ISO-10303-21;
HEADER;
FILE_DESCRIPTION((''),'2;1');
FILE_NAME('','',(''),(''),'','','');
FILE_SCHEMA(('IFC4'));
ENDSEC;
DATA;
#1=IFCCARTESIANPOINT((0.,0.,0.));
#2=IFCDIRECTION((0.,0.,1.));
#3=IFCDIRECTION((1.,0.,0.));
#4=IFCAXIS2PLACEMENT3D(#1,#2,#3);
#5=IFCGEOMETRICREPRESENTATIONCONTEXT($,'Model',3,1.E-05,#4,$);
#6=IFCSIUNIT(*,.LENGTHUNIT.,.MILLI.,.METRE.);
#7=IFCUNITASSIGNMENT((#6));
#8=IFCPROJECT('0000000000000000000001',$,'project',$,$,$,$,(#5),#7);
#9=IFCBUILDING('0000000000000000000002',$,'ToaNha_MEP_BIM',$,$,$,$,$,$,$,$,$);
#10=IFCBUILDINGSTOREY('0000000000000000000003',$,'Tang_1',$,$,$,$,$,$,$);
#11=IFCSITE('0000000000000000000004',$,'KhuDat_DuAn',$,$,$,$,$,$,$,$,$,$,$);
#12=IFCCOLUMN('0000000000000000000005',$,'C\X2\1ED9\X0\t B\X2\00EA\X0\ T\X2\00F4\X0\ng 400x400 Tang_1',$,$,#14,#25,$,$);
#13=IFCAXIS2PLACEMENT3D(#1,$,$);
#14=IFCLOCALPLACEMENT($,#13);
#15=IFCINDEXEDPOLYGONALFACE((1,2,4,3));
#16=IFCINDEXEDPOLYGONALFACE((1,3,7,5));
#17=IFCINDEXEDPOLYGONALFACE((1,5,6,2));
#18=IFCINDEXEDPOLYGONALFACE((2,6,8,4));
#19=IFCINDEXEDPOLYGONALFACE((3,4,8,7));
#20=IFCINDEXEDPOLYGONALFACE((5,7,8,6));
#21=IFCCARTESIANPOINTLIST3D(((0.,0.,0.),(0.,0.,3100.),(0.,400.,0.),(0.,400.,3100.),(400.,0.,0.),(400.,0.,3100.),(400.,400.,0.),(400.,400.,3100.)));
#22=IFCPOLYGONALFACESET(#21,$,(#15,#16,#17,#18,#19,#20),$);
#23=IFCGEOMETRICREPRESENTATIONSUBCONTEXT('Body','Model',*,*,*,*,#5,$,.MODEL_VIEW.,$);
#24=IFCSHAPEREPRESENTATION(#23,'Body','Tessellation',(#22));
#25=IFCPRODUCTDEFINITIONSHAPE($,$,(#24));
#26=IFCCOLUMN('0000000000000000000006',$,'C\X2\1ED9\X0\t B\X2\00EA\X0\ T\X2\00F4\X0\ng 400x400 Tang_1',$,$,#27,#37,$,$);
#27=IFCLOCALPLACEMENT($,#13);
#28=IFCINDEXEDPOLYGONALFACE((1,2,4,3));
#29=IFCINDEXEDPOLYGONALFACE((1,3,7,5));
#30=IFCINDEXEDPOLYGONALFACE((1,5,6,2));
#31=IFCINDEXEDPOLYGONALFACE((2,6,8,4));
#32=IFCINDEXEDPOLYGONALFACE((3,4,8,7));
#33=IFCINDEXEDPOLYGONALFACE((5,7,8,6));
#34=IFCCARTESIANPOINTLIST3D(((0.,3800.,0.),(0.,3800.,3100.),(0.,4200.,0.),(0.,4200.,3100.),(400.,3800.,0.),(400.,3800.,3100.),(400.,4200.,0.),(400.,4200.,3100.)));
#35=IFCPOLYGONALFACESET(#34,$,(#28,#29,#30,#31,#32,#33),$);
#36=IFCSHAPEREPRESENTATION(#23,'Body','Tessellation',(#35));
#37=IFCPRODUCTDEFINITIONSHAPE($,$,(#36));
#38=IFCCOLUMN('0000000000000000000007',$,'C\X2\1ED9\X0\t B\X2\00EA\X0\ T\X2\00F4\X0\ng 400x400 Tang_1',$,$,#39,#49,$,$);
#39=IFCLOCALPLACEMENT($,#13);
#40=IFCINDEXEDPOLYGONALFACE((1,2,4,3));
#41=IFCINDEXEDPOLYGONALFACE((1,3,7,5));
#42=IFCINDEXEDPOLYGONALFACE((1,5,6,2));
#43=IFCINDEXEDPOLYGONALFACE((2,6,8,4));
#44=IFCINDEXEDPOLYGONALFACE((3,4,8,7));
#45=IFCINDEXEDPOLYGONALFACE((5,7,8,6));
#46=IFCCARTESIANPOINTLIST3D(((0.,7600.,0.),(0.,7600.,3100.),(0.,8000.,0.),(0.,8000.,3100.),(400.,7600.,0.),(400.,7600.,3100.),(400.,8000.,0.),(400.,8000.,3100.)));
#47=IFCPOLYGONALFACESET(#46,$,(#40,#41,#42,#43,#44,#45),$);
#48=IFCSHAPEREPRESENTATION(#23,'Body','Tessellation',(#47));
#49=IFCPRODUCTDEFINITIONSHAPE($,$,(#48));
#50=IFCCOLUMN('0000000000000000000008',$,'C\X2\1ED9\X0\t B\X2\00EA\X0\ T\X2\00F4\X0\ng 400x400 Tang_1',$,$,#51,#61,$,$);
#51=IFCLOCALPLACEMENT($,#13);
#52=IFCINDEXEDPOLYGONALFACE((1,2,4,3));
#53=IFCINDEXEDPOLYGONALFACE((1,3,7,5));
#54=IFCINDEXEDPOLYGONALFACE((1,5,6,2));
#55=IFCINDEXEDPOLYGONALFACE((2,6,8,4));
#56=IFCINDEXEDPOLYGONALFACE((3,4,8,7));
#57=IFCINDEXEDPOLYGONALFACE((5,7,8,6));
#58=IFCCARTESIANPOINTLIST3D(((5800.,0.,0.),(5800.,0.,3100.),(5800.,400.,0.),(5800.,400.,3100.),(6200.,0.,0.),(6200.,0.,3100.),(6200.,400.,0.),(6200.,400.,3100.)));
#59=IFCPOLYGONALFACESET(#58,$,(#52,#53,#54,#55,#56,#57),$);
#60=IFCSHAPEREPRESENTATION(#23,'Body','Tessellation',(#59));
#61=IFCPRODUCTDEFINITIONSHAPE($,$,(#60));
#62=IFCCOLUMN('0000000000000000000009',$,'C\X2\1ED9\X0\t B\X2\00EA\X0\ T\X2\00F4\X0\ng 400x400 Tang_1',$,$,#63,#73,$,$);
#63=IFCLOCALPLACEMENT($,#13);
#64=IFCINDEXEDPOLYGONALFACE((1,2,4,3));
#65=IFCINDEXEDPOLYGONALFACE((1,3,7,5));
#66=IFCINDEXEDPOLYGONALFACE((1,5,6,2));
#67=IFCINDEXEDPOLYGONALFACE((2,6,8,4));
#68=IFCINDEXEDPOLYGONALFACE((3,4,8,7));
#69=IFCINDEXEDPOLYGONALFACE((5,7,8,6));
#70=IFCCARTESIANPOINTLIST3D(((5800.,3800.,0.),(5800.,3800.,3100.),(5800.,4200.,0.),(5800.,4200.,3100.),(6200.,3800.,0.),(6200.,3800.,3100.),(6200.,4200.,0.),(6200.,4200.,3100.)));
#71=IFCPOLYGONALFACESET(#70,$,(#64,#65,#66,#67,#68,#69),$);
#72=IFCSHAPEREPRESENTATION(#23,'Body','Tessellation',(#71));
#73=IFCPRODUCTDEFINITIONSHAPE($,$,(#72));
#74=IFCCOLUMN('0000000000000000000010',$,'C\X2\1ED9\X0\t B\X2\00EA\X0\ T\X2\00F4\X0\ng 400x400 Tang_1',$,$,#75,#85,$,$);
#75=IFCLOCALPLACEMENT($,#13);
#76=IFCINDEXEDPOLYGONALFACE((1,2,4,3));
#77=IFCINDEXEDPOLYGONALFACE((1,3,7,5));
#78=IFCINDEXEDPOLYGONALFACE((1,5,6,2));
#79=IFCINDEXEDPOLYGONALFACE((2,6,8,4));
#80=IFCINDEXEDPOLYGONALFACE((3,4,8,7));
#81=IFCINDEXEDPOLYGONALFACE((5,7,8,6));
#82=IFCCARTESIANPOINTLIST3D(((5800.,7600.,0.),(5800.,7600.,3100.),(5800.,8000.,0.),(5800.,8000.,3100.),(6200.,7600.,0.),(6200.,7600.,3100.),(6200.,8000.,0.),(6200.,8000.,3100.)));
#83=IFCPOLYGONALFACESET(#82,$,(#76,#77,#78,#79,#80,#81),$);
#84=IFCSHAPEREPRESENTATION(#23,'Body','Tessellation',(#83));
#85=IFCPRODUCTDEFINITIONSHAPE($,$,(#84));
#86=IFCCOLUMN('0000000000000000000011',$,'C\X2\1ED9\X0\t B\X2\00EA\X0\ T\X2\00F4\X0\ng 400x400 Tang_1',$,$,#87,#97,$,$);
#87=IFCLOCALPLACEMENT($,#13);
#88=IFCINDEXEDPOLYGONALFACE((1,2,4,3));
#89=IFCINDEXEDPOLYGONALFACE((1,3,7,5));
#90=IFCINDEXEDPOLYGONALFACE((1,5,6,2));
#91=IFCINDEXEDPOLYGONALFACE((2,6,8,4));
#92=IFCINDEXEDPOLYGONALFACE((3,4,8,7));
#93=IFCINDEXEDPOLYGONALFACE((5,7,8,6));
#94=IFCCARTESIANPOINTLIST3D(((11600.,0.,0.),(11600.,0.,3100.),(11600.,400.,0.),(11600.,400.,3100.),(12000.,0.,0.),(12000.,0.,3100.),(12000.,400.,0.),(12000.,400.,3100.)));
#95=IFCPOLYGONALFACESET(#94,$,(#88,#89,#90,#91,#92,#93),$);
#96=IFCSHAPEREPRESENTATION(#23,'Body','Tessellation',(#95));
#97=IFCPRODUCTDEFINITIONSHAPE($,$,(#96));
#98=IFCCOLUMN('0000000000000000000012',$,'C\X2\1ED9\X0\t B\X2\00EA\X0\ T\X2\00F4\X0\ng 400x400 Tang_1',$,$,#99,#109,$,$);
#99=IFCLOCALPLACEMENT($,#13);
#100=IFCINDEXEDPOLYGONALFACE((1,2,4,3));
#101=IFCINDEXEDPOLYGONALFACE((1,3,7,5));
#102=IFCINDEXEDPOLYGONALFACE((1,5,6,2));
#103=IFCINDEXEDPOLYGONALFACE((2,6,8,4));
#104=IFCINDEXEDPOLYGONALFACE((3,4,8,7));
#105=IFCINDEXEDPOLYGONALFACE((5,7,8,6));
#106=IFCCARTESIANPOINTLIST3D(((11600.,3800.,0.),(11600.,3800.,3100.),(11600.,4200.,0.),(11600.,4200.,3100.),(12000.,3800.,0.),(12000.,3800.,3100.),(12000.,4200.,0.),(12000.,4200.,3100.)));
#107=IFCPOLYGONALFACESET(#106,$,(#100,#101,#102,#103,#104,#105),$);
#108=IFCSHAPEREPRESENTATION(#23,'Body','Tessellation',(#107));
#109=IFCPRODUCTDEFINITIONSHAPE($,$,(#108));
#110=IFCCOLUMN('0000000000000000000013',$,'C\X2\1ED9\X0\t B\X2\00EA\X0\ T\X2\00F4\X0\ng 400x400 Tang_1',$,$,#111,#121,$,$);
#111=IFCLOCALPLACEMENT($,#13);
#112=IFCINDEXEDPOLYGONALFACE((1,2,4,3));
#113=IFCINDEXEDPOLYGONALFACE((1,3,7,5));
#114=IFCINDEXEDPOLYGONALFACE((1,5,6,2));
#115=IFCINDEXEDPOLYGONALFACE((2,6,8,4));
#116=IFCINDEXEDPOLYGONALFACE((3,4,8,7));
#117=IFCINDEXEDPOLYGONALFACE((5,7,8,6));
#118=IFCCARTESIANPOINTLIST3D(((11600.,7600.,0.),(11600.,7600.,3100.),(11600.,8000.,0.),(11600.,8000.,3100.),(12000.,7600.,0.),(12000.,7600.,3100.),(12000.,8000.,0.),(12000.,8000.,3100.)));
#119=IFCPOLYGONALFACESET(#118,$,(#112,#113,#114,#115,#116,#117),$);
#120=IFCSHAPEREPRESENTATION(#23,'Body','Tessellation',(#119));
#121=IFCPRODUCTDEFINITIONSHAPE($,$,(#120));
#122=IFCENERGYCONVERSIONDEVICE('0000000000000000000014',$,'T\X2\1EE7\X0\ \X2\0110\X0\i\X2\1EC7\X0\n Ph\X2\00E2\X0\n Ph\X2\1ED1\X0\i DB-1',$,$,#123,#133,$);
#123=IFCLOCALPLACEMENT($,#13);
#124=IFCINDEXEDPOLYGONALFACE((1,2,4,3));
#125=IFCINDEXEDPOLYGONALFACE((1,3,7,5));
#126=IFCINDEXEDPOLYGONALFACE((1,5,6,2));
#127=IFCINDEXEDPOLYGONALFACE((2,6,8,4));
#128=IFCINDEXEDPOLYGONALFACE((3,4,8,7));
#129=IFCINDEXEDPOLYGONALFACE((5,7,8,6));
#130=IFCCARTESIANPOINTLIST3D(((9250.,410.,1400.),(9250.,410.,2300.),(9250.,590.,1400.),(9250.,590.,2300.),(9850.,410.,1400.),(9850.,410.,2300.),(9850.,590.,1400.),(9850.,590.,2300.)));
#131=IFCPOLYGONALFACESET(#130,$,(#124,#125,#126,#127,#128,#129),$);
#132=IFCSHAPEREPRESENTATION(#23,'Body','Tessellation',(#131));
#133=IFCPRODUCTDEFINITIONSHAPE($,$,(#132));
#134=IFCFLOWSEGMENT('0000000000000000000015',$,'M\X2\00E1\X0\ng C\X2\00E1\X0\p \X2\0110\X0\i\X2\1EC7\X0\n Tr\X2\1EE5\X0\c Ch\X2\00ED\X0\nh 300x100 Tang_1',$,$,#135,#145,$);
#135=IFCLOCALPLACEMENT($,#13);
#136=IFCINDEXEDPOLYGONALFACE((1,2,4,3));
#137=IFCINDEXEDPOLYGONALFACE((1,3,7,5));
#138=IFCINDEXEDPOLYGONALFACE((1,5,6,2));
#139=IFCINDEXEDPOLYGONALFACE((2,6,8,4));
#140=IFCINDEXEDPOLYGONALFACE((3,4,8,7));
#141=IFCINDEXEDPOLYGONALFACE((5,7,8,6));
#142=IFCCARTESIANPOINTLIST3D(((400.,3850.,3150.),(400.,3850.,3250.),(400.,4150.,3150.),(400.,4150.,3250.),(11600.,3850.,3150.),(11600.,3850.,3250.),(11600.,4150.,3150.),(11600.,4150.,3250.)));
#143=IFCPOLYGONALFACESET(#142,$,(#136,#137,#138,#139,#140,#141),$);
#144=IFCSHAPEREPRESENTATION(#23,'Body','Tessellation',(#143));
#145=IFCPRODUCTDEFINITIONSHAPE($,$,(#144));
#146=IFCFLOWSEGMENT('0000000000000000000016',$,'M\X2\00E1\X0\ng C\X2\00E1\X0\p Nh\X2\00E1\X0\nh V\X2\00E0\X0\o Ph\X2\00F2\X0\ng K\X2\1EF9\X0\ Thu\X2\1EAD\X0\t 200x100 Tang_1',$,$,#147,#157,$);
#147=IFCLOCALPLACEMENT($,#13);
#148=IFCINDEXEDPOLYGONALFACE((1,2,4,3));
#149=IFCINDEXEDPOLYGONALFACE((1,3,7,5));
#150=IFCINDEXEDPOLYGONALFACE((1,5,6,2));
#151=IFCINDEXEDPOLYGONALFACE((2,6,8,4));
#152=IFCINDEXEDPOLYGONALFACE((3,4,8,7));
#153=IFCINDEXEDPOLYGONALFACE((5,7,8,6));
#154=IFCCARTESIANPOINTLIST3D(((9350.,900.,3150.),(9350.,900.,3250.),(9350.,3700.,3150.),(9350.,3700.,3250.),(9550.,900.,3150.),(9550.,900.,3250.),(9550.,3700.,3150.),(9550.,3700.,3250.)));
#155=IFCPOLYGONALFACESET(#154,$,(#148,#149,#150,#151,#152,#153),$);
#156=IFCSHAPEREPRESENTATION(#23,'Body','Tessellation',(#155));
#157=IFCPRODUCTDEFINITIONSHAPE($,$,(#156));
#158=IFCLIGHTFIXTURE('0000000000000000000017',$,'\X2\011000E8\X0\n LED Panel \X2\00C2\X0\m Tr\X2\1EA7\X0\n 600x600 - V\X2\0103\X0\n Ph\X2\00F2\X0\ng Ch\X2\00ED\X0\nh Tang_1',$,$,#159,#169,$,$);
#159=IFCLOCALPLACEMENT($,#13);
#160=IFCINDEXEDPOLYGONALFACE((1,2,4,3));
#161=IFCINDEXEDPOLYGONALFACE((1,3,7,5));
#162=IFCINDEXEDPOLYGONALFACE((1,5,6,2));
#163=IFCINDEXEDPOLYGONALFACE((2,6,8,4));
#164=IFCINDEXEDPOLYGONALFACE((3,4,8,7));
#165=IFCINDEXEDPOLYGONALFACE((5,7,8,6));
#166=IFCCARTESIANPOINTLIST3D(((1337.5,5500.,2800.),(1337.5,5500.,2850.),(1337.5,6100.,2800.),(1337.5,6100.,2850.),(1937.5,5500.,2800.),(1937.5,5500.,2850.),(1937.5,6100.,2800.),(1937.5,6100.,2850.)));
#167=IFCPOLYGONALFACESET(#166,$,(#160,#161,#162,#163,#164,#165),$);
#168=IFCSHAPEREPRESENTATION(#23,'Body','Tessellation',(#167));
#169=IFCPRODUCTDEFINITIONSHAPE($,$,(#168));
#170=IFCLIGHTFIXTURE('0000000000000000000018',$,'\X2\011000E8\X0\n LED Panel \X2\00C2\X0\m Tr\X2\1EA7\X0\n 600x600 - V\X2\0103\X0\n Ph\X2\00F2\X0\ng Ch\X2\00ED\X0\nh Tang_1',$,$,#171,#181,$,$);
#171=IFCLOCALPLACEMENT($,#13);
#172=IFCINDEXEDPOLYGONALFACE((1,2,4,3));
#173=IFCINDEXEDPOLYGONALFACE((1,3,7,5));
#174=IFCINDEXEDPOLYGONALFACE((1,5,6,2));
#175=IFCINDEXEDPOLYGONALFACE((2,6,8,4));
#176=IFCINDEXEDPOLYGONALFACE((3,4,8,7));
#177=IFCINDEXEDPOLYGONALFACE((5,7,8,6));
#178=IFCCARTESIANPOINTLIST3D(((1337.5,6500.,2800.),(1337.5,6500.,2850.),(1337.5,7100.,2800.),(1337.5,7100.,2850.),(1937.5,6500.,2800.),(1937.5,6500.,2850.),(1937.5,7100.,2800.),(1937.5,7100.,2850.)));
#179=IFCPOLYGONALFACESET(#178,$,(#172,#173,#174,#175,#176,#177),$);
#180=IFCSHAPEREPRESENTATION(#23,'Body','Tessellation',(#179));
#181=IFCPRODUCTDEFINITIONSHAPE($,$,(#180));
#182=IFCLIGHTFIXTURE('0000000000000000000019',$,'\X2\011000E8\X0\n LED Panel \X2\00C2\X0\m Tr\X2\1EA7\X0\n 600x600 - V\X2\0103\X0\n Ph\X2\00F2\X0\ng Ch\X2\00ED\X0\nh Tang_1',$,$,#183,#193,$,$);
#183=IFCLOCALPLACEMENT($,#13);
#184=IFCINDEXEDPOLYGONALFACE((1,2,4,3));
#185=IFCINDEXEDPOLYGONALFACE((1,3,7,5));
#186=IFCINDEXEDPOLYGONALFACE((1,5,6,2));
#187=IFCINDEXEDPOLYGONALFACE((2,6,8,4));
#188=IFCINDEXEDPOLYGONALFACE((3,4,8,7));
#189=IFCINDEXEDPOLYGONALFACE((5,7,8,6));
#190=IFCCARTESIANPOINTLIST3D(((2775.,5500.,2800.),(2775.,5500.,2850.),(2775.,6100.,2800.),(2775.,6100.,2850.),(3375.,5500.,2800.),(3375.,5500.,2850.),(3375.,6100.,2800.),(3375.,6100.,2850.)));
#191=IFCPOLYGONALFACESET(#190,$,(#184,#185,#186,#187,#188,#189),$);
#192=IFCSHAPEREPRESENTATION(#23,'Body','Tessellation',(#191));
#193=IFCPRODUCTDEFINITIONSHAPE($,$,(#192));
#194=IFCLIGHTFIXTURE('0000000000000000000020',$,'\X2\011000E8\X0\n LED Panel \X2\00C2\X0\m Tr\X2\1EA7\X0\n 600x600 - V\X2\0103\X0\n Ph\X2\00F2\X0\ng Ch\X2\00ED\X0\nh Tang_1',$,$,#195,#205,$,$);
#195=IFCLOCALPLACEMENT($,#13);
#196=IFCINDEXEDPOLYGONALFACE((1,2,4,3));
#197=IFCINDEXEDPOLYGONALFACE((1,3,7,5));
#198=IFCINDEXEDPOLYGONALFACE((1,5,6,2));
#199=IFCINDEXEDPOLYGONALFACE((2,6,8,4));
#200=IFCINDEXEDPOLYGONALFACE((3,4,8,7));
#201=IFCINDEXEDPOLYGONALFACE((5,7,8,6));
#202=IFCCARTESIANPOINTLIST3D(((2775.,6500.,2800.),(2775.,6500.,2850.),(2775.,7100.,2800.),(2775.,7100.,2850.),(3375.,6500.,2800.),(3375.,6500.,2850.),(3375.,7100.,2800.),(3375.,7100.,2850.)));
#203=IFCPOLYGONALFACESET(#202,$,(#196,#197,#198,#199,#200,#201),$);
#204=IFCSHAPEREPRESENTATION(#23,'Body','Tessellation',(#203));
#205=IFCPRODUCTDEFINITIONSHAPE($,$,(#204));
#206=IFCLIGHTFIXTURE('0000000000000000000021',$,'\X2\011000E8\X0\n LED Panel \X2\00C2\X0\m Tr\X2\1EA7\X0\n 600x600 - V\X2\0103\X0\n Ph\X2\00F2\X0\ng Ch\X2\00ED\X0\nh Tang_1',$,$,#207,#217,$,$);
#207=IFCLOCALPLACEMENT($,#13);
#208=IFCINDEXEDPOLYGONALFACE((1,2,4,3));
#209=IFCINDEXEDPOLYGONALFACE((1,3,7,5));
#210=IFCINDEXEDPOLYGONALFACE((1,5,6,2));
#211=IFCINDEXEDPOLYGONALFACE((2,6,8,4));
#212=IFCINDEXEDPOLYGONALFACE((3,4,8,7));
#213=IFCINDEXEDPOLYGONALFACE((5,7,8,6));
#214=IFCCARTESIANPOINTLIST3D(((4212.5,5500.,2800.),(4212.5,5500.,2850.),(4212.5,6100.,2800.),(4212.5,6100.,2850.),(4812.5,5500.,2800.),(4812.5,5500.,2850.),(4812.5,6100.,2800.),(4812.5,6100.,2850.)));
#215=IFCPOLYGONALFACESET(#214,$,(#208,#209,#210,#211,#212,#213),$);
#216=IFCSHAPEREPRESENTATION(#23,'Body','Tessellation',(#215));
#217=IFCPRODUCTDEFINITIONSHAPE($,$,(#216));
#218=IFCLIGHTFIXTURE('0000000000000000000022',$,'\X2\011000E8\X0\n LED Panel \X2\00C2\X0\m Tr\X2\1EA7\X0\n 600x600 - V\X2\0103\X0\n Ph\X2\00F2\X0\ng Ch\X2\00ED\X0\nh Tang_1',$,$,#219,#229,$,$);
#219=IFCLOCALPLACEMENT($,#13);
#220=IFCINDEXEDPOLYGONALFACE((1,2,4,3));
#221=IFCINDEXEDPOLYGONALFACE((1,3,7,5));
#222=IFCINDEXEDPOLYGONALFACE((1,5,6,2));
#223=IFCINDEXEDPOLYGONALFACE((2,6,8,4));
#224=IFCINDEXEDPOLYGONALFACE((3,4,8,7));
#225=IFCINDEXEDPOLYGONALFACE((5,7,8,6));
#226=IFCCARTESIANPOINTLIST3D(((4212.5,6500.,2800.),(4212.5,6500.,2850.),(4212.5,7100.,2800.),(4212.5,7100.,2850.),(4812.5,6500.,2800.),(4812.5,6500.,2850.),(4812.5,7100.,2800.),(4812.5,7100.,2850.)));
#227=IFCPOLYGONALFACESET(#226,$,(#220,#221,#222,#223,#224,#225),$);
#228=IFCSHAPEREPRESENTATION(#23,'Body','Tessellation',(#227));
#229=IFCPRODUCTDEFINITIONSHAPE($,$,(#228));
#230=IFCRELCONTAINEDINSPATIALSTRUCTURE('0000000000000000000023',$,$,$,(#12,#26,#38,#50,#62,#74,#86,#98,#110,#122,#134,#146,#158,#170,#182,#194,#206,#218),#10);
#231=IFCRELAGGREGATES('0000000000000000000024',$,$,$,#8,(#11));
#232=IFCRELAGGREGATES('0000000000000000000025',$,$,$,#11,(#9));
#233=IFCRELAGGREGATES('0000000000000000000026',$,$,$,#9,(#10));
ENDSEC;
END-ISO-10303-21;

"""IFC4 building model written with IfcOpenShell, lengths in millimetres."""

from ifc_helpers import new_model, si_unit, frame, origin_with_axes, context, subcontext, project, spatial, polyline, outline, extrude, element, save


model = new_model("IFC4")

# Units and contexts
model_context = context("Model", 3, precision=1e-05, world=origin_with_axes())
body_context = subcontext(model_context, "Body", "Model", "MODEL_VIEW")
ifc_project = project(units=[si_unit("LENGTHUNIT", "METRE", prefix="MILLI")], contexts=[model_context])

# Site, building, storey
site = spatial("IfcSite", under=ifc_project, Name="KhuDat_DuAn")
building = spatial("IfcBuilding", under=site, Name="ToaNha_MEP_BIM")
storey = spatial("IfcBuildingStorey", under=building, Name="Tang_1")

# Columns
element("IfcColumn", 1, inside=storey, Name="Cột Bê Tông 400x400 Tang_1", context=body_context, shape_type="SweptSolid", body=[
    extrude(outline(polyline([(0.0, 0.0), (400.0, 0.0), (400.0, 400.0), (0.0, 400.0), (0.0, 0.0)])), origin_with_axes(), (0.0, 0.0, 1.0), 3100.0),
])
element("IfcColumn", 2, inside=storey, Name="Cột Bê Tông 400x400 Tang_1", context=body_context, shape_type="SweptSolid", body=[
    extrude(outline(polyline([(0.0, 3800.0), (400.0, 3800.0), (400.0, 4200.0), (0.0, 4200.0), (0.0, 3800.0)])), origin_with_axes(), (0.0, 0.0, 1.0), 3100.0),
])
element("IfcColumn", 3, inside=storey, Name="Cột Bê Tông 400x400 Tang_1", context=body_context, shape_type="SweptSolid", body=[
    extrude(outline(polyline([(0.0, 7600.0), (400.0, 7600.0), (400.0, 8000.0), (0.0, 8000.0), (0.0, 7600.0)])), origin_with_axes(), (0.0, 0.0, 1.0), 3100.0),
])
element("IfcColumn", 4, inside=storey, Name="Cột Bê Tông 400x400 Tang_1", context=body_context, shape_type="SweptSolid", body=[
    extrude(outline(polyline([(5800.0, 0.0), (6200.0, 0.0), (6200.0, 400.0), (5800.0, 400.0), (5800.0, 0.0)])), origin_with_axes(), (0.0, 0.0, 1.0), 3100.0),
])
element("IfcColumn", 5, inside=storey, Name="Cột Bê Tông 400x400 Tang_1", context=body_context, shape_type="SweptSolid", body=[
    extrude(outline(polyline([(5800.0, 3800.0), (6200.0, 3800.0), (6200.0, 4200.0), (5800.0, 4200.0), (5800.0, 3800.0)])), origin_with_axes(), (0.0, 0.0, 1.0), 3100.0),
])
element("IfcColumn", 6, inside=storey, Name="Cột Bê Tông 400x400 Tang_1", context=body_context, shape_type="SweptSolid", body=[
    extrude(outline(polyline([(5800.0, 7600.0), (6200.0, 7600.0), (6200.0, 8000.0), (5800.0, 8000.0), (5800.0, 7600.0)])), origin_with_axes(), (0.0, 0.0, 1.0), 3100.0),
])
element("IfcColumn", 7, inside=storey, Name="Cột Bê Tông 400x400 Tang_1", context=body_context, shape_type="SweptSolid", body=[
    extrude(outline(polyline([(11600.0, 0.0), (12000.0, 0.0), (12000.0, 400.0), (11600.0, 400.0), (11600.0, 0.0)])), origin_with_axes(), (0.0, 0.0, 1.0), 3100.0),
])
element("IfcColumn", 8, inside=storey, Name="Cột Bê Tông 400x400 Tang_1", context=body_context, shape_type="SweptSolid", body=[
    extrude(outline(polyline([(11600.0, 3800.0), (12000.0, 3800.0), (12000.0, 4200.0), (11600.0, 4200.0), (11600.0, 3800.0)])), origin_with_axes(), (0.0, 0.0, 1.0), 3100.0),
])
element("IfcColumn", 9, inside=storey, Name="Cột Bê Tông 400x400 Tang_1", context=body_context, shape_type="SweptSolid", body=[
    extrude(outline(polyline([(11600.0, 7600.0), (12000.0, 7600.0), (12000.0, 8000.0), (11600.0, 8000.0), (11600.0, 7600.0)])), origin_with_axes(), (0.0, 0.0, 1.0), 3100.0),
])

# Energy conversion device
element("IfcEnergyConversionDevice", 10, inside=storey, Name="Tủ Điện Phân Phối DB-1", context=body_context, shape_type="SweptSolid", body=[
    extrude(outline(polyline([(9250.0, 410.0), (9850.0, 410.0), (9850.0, 590.0), (9250.0, 590.0), (9250.0, 410.0)])), frame((0.0, 0.0, 1400.0), z_axis=(0.0, 0.0, 1.0), x_axis=(1.0, 0.0, 0.0)), (0.0, 0.0, 1.0), 900.0),
])

# Flow segments
element("IfcFlowSegment", 11, inside=storey, Name="Máng Cáp Điện Trục Chính 300x100 Tang_1", context=body_context, shape_type="SweptSolid", body=[
    extrude(outline(polyline([(400.0, 3850.0), (11600.0, 3850.0), (11600.0, 4150.0), (400.0, 4150.0), (400.0, 3850.0)])), frame((0.0, 0.0, 3150.0), z_axis=(0.0, 0.0, 1.0), x_axis=(1.0, 0.0, 0.0)), (0.0, 0.0, 1.0), 100.0),
])
element("IfcFlowSegment", 12, inside=storey, Name="Máng Cáp Nhánh Vào Phòng Kỹ Thuật 200x100 Tang_1", context=body_context, shape_type="SweptSolid", body=[
    extrude(outline(polyline([(9350.0, 900.0), (9550.0, 900.0), (9550.0, 3700.0), (9350.0, 3700.0), (9350.0, 900.0)])), frame((0.0, 0.0, 3150.0), z_axis=(0.0, 0.0, 1.0), x_axis=(1.0, 0.0, 0.0)), (0.0, 0.0, 1.0), 100.0),
])

# Light fixtures
element("IfcLightFixture", 13, inside=storey, Name="Đèn LED Panel Âm Trần 600x600 - Văn Phòng Chính Tang_1", context=body_context, shape_type="SweptSolid", body=[
    extrude(outline(polyline([(1337.5, 5500.0), (1937.5, 5500.0), (1937.5, 6100.0), (1337.5, 6100.0), (1337.5, 5500.0)])), frame((0.0, 0.0, 2800.0), z_axis=(0.0, 0.0, 1.0), x_axis=(1.0, 0.0, 0.0)), (0.0, 0.0, 1.0), 50.0),
])
element("IfcLightFixture", 14, inside=storey, Name="Đèn LED Panel Âm Trần 600x600 - Văn Phòng Chính Tang_1", context=body_context, shape_type="SweptSolid", body=[
    extrude(outline(polyline([(1337.5, 6500.0), (1937.5, 6500.0), (1937.5, 7100.0), (1337.5, 7100.0), (1337.5, 6500.0)])), frame((0.0, 0.0, 2800.0), z_axis=(0.0, 0.0, 1.0), x_axis=(1.0, 0.0, 0.0)), (0.0, 0.0, 1.0), 50.0),
])
element("IfcLightFixture", 15, inside=storey, Name="Đèn LED Panel Âm Trần 600x600 - Văn Phòng Chính Tang_1", context=body_context, shape_type="SweptSolid", body=[
    extrude(outline(polyline([(2775.0, 5500.0), (3375.0, 5500.0), (3375.0, 6100.0), (2775.0, 6100.0), (2775.0, 5500.0)])), frame((0.0, 0.0, 2800.0), z_axis=(0.0, 0.0, 1.0), x_axis=(1.0, 0.0, 0.0)), (0.0, 0.0, 1.0), 50.0),
])
element("IfcLightFixture", 16, inside=storey, Name="Đèn LED Panel Âm Trần 600x600 - Văn Phòng Chính Tang_1", context=body_context, shape_type="SweptSolid", body=[
    extrude(outline(polyline([(2775.0, 6500.0), (3375.0, 6500.0), (3375.0, 7100.0), (2775.0, 7100.0), (2775.0, 6500.0)])), frame((0.0, 0.0, 2800.0), z_axis=(0.0, 0.0, 1.0), x_axis=(1.0, 0.0, 0.0)), (0.0, 0.0, 1.0), 50.0),
])
element("IfcLightFixture", 17, inside=storey, Name="Đèn LED Panel Âm Trần 600x600 - Văn Phòng Chính Tang_1", context=body_context, shape_type="SweptSolid", body=[
    extrude(outline(polyline([(4212.5, 5500.0), (4812.5, 5500.0), (4812.5, 6100.0), (4212.5, 6100.0), (4212.5, 5500.0)])), frame((0.0, 0.0, 2800.0), z_axis=(0.0, 0.0, 1.0), x_axis=(1.0, 0.0, 0.0)), (0.0, 0.0, 1.0), 50.0),
])
element("IfcLightFixture", 18, inside=storey, Name="Đèn LED Panel Âm Trần 600x600 - Văn Phòng Chính Tang_1", context=body_context, shape_type="SweptSolid", body=[
    extrude(outline(polyline([(4212.5, 6500.0), (4812.5, 6500.0), (4812.5, 7100.0), (4212.5, 7100.0), (4212.5, 6500.0)])), frame((0.0, 0.0, 2800.0), z_axis=(0.0, 0.0, 1.0), x_axis=(1.0, 0.0, 0.0)), (0.0, 0.0, 1.0), 50.0),
])

save(model, "model.ifc")
